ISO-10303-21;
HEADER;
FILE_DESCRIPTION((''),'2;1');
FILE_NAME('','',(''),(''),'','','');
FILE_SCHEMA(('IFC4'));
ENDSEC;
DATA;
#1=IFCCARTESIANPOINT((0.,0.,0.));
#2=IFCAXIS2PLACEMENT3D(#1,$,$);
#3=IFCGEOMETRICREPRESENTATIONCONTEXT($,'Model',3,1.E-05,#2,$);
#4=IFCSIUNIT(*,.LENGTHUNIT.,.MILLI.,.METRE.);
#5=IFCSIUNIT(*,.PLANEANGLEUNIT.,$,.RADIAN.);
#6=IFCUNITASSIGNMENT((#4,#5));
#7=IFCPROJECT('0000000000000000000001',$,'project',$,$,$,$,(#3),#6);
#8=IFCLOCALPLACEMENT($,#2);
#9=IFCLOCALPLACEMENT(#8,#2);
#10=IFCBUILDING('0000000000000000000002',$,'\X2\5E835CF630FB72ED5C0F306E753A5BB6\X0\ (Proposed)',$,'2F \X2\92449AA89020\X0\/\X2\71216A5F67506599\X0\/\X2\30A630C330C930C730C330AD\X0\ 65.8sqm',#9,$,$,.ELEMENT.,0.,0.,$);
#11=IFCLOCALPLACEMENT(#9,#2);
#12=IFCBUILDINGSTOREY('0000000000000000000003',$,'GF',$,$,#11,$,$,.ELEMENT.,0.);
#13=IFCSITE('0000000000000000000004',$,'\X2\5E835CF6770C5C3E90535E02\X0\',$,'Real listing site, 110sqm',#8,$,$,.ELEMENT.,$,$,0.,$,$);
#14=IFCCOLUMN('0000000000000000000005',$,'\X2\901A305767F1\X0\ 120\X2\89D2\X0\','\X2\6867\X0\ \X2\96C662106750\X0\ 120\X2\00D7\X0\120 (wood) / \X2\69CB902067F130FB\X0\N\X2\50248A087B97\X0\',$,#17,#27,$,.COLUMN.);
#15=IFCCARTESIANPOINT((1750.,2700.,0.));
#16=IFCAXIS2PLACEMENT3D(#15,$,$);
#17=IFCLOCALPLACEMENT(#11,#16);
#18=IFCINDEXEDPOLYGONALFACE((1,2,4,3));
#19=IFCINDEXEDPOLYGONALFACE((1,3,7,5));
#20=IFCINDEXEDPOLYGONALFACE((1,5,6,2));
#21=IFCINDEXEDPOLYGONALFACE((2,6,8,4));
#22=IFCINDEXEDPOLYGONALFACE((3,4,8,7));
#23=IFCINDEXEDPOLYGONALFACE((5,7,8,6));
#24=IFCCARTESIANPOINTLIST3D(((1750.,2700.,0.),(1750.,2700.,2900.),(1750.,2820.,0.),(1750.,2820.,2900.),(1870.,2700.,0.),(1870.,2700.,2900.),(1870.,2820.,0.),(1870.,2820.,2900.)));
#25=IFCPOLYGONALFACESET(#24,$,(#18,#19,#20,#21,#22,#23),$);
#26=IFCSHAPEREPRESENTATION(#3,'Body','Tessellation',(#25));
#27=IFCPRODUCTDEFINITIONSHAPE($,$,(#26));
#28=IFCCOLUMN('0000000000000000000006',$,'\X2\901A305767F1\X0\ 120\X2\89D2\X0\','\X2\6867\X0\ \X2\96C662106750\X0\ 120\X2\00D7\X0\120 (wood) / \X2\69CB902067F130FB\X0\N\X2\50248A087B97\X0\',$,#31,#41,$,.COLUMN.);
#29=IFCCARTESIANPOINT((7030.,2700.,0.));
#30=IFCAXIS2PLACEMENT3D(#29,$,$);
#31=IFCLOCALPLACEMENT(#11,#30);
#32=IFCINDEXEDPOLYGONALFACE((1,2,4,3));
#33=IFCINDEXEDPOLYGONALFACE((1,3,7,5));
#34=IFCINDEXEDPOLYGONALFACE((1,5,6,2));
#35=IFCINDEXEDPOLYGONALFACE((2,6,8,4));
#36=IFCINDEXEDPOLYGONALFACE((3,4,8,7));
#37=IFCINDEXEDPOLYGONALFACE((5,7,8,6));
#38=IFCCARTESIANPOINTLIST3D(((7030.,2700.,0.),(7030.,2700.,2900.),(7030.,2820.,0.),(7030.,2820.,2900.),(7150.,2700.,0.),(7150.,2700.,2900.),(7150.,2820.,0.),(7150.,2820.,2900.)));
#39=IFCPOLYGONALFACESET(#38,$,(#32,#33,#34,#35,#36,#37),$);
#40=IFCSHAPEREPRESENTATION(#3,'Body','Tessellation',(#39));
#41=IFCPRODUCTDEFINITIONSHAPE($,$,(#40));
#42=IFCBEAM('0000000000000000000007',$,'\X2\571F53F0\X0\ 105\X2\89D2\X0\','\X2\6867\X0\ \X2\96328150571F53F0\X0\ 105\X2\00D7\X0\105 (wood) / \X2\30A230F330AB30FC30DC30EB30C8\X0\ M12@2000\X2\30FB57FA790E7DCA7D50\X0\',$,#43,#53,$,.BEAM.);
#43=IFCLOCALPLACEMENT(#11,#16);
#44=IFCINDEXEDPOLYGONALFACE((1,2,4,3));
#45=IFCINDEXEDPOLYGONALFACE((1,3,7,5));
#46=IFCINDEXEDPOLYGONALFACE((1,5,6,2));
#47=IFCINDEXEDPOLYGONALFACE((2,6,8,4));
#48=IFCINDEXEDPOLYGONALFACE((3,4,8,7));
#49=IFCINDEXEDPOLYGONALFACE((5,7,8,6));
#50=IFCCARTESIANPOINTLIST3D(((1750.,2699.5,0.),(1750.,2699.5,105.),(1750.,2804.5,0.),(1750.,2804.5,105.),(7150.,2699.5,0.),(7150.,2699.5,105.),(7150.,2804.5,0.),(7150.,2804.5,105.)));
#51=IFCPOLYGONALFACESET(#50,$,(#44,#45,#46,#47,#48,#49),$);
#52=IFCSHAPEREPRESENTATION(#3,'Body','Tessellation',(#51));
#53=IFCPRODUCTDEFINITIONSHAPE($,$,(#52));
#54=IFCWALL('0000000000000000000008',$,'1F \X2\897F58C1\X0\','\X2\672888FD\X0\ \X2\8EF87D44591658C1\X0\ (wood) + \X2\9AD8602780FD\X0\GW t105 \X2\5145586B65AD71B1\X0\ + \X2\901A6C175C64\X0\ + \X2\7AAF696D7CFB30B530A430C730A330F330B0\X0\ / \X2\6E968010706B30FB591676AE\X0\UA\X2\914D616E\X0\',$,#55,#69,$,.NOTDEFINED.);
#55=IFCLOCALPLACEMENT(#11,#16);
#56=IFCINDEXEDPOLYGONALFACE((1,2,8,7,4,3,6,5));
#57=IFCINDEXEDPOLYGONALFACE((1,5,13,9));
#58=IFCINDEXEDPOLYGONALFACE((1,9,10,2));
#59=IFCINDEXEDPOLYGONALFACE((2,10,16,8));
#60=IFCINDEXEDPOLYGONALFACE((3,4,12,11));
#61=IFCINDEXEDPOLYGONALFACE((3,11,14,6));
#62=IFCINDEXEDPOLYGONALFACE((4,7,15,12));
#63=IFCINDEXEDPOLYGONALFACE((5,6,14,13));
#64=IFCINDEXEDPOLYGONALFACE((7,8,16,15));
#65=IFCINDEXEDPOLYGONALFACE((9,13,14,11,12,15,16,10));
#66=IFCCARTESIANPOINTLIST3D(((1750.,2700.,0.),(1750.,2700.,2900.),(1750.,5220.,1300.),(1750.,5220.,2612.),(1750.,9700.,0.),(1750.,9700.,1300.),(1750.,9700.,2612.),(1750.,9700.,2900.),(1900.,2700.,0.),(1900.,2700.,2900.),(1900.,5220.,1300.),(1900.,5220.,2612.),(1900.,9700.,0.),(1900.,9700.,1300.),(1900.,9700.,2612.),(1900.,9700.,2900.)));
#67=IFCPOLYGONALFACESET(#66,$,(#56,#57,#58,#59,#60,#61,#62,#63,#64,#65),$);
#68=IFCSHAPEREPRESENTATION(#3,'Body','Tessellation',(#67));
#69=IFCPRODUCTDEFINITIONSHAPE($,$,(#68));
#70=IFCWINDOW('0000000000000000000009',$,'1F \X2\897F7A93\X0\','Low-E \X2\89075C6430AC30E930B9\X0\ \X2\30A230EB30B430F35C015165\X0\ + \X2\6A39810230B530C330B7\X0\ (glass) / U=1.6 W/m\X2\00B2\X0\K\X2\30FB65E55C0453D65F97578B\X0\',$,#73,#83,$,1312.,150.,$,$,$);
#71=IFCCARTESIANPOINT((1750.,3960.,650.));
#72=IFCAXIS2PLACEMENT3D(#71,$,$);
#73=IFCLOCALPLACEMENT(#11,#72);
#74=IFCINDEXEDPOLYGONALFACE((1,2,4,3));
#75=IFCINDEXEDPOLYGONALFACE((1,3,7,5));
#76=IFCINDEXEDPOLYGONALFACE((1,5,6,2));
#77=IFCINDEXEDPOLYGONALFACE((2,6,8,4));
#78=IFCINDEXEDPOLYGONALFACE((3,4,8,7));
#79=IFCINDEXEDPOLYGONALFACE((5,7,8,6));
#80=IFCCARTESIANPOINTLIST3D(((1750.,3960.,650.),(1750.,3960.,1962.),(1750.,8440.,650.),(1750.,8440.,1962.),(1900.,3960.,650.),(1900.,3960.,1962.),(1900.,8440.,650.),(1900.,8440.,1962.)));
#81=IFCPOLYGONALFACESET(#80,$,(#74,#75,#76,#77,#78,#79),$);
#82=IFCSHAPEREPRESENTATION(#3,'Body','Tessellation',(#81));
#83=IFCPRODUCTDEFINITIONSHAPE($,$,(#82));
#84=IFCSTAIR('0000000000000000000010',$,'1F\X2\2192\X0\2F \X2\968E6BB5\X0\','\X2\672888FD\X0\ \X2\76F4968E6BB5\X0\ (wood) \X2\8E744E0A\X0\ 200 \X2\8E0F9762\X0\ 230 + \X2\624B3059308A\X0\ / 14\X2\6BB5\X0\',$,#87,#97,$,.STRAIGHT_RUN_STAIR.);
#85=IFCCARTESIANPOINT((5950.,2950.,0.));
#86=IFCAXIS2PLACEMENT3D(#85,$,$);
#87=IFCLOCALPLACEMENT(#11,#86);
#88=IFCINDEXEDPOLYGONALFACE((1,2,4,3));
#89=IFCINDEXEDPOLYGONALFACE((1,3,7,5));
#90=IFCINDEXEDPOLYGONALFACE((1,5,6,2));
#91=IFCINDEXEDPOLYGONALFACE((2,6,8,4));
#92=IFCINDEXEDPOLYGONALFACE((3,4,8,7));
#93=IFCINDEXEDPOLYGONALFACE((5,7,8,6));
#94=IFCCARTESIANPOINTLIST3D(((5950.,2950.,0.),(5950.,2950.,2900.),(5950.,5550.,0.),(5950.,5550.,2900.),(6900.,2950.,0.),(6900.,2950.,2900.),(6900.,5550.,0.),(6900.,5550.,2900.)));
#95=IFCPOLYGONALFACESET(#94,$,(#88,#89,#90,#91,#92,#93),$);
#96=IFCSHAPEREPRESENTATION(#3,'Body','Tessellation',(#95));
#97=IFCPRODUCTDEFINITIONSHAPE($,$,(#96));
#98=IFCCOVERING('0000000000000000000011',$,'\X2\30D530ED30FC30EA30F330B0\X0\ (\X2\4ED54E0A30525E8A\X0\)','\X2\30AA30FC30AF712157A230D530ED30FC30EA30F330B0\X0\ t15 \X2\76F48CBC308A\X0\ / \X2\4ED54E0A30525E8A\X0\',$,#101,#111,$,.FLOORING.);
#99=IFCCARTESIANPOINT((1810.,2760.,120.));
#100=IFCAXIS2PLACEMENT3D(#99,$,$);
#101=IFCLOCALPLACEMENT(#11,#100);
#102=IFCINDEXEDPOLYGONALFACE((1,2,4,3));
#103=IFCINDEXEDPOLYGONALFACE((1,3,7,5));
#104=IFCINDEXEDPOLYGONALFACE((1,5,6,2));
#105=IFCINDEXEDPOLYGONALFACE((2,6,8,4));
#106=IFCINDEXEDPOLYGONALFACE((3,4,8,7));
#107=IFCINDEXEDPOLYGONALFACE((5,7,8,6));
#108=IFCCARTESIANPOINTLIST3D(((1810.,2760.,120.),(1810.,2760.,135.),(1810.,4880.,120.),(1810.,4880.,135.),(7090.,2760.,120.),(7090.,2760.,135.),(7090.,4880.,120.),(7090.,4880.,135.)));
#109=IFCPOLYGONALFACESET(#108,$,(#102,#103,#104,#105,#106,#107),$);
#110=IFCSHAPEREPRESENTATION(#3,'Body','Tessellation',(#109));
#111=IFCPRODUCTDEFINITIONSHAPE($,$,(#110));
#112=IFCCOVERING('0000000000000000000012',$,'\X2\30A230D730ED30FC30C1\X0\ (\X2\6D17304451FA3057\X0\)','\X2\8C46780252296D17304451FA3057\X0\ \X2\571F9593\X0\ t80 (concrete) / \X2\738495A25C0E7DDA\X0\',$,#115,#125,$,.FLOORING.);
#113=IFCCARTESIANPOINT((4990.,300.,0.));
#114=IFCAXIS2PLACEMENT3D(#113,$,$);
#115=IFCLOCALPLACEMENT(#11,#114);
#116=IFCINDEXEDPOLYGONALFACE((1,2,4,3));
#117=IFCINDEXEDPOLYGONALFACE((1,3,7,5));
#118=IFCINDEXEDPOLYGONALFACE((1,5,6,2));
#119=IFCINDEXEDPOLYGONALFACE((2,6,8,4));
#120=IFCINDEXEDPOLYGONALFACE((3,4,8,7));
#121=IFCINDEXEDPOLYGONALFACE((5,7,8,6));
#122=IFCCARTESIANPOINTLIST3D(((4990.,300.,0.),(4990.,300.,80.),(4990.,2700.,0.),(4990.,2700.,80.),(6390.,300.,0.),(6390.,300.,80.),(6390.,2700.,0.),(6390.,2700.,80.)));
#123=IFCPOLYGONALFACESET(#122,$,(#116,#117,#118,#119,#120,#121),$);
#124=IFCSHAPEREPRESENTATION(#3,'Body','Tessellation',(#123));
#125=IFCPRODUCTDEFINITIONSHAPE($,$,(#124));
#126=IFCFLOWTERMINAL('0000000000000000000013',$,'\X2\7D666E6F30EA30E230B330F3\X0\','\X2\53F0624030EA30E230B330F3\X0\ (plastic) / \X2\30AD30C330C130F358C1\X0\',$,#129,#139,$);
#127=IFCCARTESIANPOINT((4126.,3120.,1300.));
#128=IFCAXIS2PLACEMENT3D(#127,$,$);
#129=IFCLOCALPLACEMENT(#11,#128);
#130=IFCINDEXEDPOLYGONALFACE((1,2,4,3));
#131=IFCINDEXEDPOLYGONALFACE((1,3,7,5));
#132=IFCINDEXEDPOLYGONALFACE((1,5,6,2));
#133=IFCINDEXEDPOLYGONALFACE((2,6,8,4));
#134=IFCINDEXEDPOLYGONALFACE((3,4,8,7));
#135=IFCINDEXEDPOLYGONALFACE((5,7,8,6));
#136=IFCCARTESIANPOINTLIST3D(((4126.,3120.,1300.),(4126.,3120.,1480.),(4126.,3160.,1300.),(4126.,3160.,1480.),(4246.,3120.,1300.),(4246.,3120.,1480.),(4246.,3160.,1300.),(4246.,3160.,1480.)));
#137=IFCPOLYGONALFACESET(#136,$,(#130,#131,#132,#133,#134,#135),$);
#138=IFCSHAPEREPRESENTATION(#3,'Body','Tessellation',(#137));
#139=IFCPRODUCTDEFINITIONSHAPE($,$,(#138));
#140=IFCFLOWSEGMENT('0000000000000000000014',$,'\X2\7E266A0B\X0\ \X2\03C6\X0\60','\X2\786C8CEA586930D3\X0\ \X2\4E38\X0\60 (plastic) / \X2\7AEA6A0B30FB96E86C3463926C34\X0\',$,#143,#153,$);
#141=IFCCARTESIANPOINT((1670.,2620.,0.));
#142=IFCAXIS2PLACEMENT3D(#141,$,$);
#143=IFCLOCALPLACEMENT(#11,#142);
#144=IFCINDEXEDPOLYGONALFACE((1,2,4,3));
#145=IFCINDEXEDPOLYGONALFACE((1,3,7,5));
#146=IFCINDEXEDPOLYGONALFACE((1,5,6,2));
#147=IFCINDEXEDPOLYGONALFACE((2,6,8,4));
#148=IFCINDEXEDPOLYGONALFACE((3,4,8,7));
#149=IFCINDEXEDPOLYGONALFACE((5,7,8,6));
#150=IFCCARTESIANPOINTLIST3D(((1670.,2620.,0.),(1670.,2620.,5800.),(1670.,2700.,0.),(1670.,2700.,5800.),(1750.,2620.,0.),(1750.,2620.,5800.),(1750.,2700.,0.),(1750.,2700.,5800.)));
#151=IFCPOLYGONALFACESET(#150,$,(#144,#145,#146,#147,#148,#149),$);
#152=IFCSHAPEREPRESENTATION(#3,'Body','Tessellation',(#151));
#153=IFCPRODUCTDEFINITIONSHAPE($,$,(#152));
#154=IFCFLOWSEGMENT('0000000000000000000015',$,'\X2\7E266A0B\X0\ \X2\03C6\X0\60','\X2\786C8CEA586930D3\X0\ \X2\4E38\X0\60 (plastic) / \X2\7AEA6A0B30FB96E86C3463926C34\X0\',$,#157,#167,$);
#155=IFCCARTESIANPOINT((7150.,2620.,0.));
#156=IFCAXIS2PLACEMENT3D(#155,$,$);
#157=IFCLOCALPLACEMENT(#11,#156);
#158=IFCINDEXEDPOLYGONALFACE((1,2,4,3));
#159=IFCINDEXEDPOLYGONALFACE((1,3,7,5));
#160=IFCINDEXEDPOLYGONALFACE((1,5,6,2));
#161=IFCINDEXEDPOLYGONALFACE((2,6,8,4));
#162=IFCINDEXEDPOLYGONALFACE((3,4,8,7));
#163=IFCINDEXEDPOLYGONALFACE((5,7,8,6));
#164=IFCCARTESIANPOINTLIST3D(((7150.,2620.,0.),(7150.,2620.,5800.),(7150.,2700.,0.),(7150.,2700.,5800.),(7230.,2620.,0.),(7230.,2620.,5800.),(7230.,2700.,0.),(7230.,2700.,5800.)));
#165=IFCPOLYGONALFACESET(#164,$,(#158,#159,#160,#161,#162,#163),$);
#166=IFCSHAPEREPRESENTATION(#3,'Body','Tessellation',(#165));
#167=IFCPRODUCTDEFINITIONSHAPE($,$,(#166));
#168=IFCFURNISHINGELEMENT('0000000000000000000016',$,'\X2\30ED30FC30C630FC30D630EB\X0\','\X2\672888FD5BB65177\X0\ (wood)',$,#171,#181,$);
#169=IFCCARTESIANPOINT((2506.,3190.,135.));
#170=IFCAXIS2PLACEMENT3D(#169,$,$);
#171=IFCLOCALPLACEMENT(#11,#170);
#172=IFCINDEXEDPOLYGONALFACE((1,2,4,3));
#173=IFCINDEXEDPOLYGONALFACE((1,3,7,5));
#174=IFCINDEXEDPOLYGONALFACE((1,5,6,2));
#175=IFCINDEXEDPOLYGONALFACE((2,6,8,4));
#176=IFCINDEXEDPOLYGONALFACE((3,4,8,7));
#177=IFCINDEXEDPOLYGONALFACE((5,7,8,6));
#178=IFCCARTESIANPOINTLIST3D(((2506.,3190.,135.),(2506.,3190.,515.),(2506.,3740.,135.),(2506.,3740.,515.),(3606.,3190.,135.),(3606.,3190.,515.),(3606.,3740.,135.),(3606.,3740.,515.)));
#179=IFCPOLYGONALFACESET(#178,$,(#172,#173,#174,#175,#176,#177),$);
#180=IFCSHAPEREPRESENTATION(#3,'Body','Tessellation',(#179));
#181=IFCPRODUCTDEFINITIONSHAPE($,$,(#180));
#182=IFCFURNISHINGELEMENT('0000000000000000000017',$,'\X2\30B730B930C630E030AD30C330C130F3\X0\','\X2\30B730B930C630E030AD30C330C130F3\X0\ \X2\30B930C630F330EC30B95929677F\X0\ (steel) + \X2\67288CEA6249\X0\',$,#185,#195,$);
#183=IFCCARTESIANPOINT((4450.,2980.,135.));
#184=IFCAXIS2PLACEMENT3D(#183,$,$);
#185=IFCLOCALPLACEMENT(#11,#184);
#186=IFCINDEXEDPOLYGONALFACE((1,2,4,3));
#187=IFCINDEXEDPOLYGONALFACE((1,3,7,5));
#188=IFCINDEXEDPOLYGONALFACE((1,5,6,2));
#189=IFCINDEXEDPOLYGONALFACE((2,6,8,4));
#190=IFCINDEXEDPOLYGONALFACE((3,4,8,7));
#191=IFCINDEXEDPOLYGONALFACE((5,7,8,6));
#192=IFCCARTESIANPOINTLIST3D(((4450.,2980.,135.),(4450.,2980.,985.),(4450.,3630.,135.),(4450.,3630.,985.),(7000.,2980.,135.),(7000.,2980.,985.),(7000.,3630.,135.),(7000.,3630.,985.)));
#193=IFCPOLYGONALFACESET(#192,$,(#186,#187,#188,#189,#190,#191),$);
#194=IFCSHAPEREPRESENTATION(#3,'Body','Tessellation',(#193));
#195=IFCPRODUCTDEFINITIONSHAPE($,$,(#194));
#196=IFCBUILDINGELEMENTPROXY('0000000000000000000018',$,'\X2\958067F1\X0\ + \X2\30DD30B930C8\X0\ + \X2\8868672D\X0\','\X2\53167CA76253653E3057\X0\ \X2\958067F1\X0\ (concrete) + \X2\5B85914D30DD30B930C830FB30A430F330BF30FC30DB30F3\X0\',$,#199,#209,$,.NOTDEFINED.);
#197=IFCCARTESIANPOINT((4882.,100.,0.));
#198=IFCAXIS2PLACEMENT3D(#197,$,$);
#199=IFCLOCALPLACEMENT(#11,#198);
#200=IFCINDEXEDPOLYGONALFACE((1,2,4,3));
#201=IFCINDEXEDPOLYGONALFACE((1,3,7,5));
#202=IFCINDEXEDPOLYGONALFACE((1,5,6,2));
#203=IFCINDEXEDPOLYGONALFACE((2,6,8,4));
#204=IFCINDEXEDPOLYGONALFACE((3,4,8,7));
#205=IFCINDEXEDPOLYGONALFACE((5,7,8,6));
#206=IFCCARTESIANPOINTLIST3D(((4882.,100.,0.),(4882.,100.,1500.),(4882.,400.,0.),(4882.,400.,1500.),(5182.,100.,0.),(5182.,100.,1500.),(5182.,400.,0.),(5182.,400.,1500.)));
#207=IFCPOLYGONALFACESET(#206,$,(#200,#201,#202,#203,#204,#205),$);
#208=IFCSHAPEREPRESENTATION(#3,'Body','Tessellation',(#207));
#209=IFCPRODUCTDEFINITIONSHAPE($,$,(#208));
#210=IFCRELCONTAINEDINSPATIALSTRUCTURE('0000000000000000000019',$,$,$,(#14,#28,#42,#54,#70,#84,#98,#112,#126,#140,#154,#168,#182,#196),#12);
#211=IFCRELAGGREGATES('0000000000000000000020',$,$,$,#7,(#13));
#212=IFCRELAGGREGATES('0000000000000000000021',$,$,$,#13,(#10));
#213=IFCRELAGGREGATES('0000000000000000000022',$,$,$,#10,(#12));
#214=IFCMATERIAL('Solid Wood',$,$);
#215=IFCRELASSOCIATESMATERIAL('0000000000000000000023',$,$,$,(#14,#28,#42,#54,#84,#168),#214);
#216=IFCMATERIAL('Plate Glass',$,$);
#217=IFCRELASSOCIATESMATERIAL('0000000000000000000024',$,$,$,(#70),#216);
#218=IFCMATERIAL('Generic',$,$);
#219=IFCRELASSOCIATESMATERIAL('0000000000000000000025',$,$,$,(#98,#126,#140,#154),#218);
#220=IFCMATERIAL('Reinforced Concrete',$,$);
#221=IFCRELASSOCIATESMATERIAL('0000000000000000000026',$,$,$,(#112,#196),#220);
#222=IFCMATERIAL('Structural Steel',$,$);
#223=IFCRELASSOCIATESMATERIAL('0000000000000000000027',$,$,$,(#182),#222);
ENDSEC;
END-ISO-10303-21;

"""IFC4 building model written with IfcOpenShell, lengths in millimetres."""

from ifc_helpers import new_model, si_unit, frame, frame_2d, origin, place, context, project, spatial, rectangle, extrude, material, element, fill, save


model = new_model("IFC4")

# Units and contexts
model_context = context("Model", 3, precision=1e-05, world=origin())
ifc_project = project(units=[si_unit("LENGTHUNIT", "METRE", prefix="MILLI"), si_unit("PLANEANGLEUNIT", "RADIAN")], contexts=[model_context])

# Site, building, storey
site_placement = place(None, origin())
site = spatial("IfcSite", under=ifc_project, at=site_placement, Name="広島県尾道市", ObjectType="Real listing site, 110sqm", CompositionType="ELEMENT", RefElevation=0.0)
building_placement = place(site_placement, origin())
building = spatial("IfcBuilding", under=site, at=building_placement, Name="広島・狭小の町家 (Proposed)", ObjectType="2F 鉄骨造/無機材料/ウッドデッキ 65.8sqm", CompositionType="ELEMENT", ElevationOfRefHeight=0.0, ElevationOfTerrain=0.0)
storey_placement = place(building_placement, origin())
storey = spatial("IfcBuildingStorey", under=building, at=storey_placement, Name="GF", CompositionType="ELEMENT", Elevation=0.0)

# Columns
ifc_material_1 = material(Name="Solid Wood")
column_1_placement = place(storey_placement, frame((1750.0, 2700.0, 0.0)))
element("IfcColumn", 1, at=column_1_placement, inside=storey, material=ifc_material_1, Name="通し柱 120角", Description="桧 集成材 120×120 (wood) / 構造柱・N値計算", PredefinedType="COLUMN", context=model_context, shape_type="SweptSolid", body=[
    extrude(rectangle(XDim=120.0, YDim=120.0, at=frame_2d((60.0, 60.0))), frame((1750.0, 2700.0, 0.0)), (0.0, 0.0, 1.0), 2900.0),
])
column_2_placement = place(storey_placement, frame((7030.0, 2700.0, 0.0)))
element("IfcColumn", 2, at=column_2_placement, inside=storey, material=ifc_material_1, Name="通し柱 120角", Description="桧 集成材 120×120 (wood) / 構造柱・N値計算", PredefinedType="COLUMN", context=model_context, shape_type="SweptSolid", body=[
    extrude(rectangle(XDim=120.0, YDim=120.0, at=frame_2d((60.0, 60.0))), frame((7030.0, 2700.0, 0.0)), (0.0, 0.0, 1.0), 2900.0),
])

# Beam
beam_1_placement = place(storey_placement, frame((1750.0, 2700.0, 0.0)))
element("IfcBeam", 3, at=beam_1_placement, inside=storey, material=ifc_material_1, Name="土台 105角", Description="桧 防腐土台 105×105 (wood) / アンカーボルト M12@2000・基礎緊結", PredefinedType="BEAM", context=model_context, shape_type="SweptSolid", body=[
    extrude(rectangle(XDim=5400.0, YDim=105.0, at=frame_2d((2700.0, 52.0))), frame((1750.0, 2700.0, 0.0)), (0.0, 0.0, 1.0), 105.0),
])

# Shared definitions
ifc_material_2 = material(Name="Reinforced Concrete")

# Shared definitions
ifc_material_3 = material(Name="Plate Glass")

# Wall, opening, window
wall_1_placement = place(storey_placement, frame((1750.0, 2700.0, 0.0)))
wall_1 = element("IfcWall", 4, at=wall_1_placement, inside=storey, material=ifc_material_1, Name="1F 西壁", Description="木製 軸組外壁 (wood) + 高性能GW t105 充填断熱 + 通気層 + 窯業系サイディング / 準耐火・外皮UA配慮", PredefinedType="NOTDEFINED", context=model_context, shape_type="SweptSolid", body=[
    extrude(rectangle(XDim=150.0, YDim=7000.0, at=frame_2d((75.0, 3500.0))), frame((1750.0, 2700.0, 0.0)), (0.0, 0.0, 1.0), 2900.0),
])
opening_1_placement = place(storey_placement, frame((1750.0, 3960.0, 650.0)))
opening_1 = element("IfcOpeningElement", 5, at=opening_1_placement, cuts=wall_1, PredefinedType="NOTDEFINED", context=model_context, shape_type="SweptSolid", body=[
    extrude(rectangle(XDim=150.0, YDim=4480.0, at=frame_2d((75.0, 2240.0))), frame((1750.0, 3960.0, 650.0)), (0.0, 0.0, 1.0), 1312.0),
])
window_1_placement = place(storey_placement, frame((1750.0, 3960.0, 650.0)))
window_1 = element("IfcWindow", 6, at=window_1_placement, inside=storey, material=ifc_material_3, Name="1F 西窓", Description="Low-E 複層ガラス アルゴン封入 + 樹脂サッシ (glass) / U=1.6 W/m²K・日射取得型", OverallHeight=1312.0, OverallWidth=150.0, context=model_context, shape_type="SweptSolid", body=[
    extrude(rectangle(XDim=150.0, YDim=4480.0, at=frame_2d((75.0, 2240.0))), frame((1750.0, 3960.0, 650.0)), (0.0, 0.0, 1.0), 1312.0),
])
fill(opening_1, window_1)

# Stair
stair_placement = place(storey_placement, frame((5950.0, 2950.0, 0.0)))
element("IfcStair", 7, at=stair_placement, inside=storey, material=ifc_material_1, Name="1F→2F 階段", Description="木製 直階段 (wood) 蹴上 200 踏面 230 + 手すり / 14段", PredefinedType="STRAIGHT_RUN_STAIR", context=model_context, shape_type="SweptSolid", body=[
    extrude(rectangle(XDim=950.0, YDim=2600.0, at=frame_2d((475.0, 1300.0))), frame((5950.0, 2950.0, 0.0)), (0.0, 0.0, 1.0), 2900.0),
])

# Coverings
ifc_material_4 = material(Name="Generic")
covering_1_placement = place(storey_placement, frame((1810.0, 2760.0, 120.0)))
element("IfcCovering", 8, at=covering_1_placement, inside=storey, material=ifc_material_4, Name="フローリング (仕上げ床)", Description="オーク無垢フローリング t15 直貼り / 仕上げ床", PredefinedType="FLOORING", context=model_context, shape_type="SweptSolid", body=[
    extrude(rectangle(XDim=5280.0, YDim=2120.0, at=frame_2d((2640.0, 1060.0))), frame((1810.0, 2760.0, 120.0)), (0.0, 0.0, 1.0), 15.0),
])
covering_2_placement = place(storey_placement, frame((4990.0, 300.0, 0.0)))
element("IfcCovering", 9, at=covering_2_placement, inside=storey, material=ifc_material_2, Name="アプローチ (洗い出し)", Description="豆砂利洗い出し 土間 t80 (concrete) / 玄関導線", PredefinedType="FLOORING", context=model_context, shape_type="SweptSolid", body=[
    extrude(rectangle(XDim=1400.0, YDim=2400.0, at=frame_2d((700.0, 1200.0))), frame((4990.0, 300.0, 0.0)), (0.0, 0.0, 1.0), 80.0),
])

# Flow terminal
flow_terminal_placement = place(storey_placement, frame((4126.0, 3120.0, 1300.0)))
element("IfcFlowTerminal", 10, at=flow_terminal_placement, inside=storey, material=ifc_material_4, Name="給湯リモコン", Description="台所リモコン (plastic) / キッチン壁", context=model_context, shape_type="SweptSolid", body=[
    extrude(rectangle(XDim=120.0, YDim=40.0, at=frame_2d((60.0, 20.0))), frame((4126.0, 3120.0, 1300.0)), (0.0, 0.0, 1.0), 180.0),
])

# Flow segments
flow_segment_1_placement = place(storey_placement, frame((1670.0, 2620.0, 0.0)))
element("IfcFlowSegment", 11, at=flow_segment_1_placement, inside=storey, material=ifc_material_4, Name="縦樋 φ60", Description="硬質塩ビ 丸60 (plastic) / 竪樋・雨水排水", context=model_context, shape_type="SweptSolid", body=[
    extrude(rectangle(XDim=80.0, YDim=80.0, at=frame_2d((40.0, 40.0))), frame((1670.0, 2620.0, 0.0)), (0.0, 0.0, 1.0), 5800.0),
])
flow_segment_2_placement = place(storey_placement, frame((7150.0, 2620.0, 0.0)))
element("IfcFlowSegment", 12, at=flow_segment_2_placement, inside=storey, material=ifc_material_4, Name="縦樋 φ60", Description="硬質塩ビ 丸60 (plastic) / 竪樋・雨水排水", context=model_context, shape_type="SweptSolid", body=[
    extrude(rectangle(XDim=80.0, YDim=80.0, at=frame_2d((40.0, 40.0))), frame((7150.0, 2620.0, 0.0)), (0.0, 0.0, 1.0), 5800.0),
])

# Furnishing elements
furnishing_1_placement = place(storey_placement, frame((2506.0, 3190.0, 135.0)))
element("IfcFurnishingElement", 13, at=furnishing_1_placement, inside=storey, material=ifc_material_1, Name="ローテーブル", Description="木製家具 (wood)", context=model_context, shape_type="SweptSolid", body=[
    extrude(rectangle(XDim=1100.0, YDim=550.0, at=frame_2d((550.0, 275.0))), frame((2506.0, 3190.0, 135.0)), (0.0, 0.0, 1.0), 380.0),
])
ifc_material_5 = material(Name="Structural Steel")
furnishing_2_placement = place(storey_placement, frame((4450.0, 2980.0, 135.0)))
element("IfcFurnishingElement", 14, at=furnishing_2_placement, inside=storey, material=ifc_material_5, Name="システムキッチン", Description="システムキッチン ステンレス天板 (steel) + 木質扉", context=model_context, shape_type="SweptSolid", body=[
    extrude(rectangle(XDim=2550.0, YDim=650.0, at=frame_2d((1275.0, 325.0))), frame((4450.0, 2980.0, 135.0)), (0.0, 0.0, 1.0), 850.0),
])

# Building element proxy
proxy_placement = place(storey_placement, frame((4882.0, 100.0, 0.0)))
element("IfcBuildingElementProxy", 15, at=proxy_placement, inside=storey, material=ifc_material_2, Name="門柱 + ポスト + 表札", Description="化粧打放し 門柱 (concrete) + 宅配ポスト・インターホン", PredefinedType="NOTDEFINED", context=model_context, shape_type="SweptSolid", body=[
    extrude(rectangle(XDim=300.0, YDim=300.0, at=frame_2d((150.0, 150.0))), frame((4882.0, 100.0, 0.0)), (0.0, 0.0, 1.0), 1500.0),
])

save(model, "model.ifc")
